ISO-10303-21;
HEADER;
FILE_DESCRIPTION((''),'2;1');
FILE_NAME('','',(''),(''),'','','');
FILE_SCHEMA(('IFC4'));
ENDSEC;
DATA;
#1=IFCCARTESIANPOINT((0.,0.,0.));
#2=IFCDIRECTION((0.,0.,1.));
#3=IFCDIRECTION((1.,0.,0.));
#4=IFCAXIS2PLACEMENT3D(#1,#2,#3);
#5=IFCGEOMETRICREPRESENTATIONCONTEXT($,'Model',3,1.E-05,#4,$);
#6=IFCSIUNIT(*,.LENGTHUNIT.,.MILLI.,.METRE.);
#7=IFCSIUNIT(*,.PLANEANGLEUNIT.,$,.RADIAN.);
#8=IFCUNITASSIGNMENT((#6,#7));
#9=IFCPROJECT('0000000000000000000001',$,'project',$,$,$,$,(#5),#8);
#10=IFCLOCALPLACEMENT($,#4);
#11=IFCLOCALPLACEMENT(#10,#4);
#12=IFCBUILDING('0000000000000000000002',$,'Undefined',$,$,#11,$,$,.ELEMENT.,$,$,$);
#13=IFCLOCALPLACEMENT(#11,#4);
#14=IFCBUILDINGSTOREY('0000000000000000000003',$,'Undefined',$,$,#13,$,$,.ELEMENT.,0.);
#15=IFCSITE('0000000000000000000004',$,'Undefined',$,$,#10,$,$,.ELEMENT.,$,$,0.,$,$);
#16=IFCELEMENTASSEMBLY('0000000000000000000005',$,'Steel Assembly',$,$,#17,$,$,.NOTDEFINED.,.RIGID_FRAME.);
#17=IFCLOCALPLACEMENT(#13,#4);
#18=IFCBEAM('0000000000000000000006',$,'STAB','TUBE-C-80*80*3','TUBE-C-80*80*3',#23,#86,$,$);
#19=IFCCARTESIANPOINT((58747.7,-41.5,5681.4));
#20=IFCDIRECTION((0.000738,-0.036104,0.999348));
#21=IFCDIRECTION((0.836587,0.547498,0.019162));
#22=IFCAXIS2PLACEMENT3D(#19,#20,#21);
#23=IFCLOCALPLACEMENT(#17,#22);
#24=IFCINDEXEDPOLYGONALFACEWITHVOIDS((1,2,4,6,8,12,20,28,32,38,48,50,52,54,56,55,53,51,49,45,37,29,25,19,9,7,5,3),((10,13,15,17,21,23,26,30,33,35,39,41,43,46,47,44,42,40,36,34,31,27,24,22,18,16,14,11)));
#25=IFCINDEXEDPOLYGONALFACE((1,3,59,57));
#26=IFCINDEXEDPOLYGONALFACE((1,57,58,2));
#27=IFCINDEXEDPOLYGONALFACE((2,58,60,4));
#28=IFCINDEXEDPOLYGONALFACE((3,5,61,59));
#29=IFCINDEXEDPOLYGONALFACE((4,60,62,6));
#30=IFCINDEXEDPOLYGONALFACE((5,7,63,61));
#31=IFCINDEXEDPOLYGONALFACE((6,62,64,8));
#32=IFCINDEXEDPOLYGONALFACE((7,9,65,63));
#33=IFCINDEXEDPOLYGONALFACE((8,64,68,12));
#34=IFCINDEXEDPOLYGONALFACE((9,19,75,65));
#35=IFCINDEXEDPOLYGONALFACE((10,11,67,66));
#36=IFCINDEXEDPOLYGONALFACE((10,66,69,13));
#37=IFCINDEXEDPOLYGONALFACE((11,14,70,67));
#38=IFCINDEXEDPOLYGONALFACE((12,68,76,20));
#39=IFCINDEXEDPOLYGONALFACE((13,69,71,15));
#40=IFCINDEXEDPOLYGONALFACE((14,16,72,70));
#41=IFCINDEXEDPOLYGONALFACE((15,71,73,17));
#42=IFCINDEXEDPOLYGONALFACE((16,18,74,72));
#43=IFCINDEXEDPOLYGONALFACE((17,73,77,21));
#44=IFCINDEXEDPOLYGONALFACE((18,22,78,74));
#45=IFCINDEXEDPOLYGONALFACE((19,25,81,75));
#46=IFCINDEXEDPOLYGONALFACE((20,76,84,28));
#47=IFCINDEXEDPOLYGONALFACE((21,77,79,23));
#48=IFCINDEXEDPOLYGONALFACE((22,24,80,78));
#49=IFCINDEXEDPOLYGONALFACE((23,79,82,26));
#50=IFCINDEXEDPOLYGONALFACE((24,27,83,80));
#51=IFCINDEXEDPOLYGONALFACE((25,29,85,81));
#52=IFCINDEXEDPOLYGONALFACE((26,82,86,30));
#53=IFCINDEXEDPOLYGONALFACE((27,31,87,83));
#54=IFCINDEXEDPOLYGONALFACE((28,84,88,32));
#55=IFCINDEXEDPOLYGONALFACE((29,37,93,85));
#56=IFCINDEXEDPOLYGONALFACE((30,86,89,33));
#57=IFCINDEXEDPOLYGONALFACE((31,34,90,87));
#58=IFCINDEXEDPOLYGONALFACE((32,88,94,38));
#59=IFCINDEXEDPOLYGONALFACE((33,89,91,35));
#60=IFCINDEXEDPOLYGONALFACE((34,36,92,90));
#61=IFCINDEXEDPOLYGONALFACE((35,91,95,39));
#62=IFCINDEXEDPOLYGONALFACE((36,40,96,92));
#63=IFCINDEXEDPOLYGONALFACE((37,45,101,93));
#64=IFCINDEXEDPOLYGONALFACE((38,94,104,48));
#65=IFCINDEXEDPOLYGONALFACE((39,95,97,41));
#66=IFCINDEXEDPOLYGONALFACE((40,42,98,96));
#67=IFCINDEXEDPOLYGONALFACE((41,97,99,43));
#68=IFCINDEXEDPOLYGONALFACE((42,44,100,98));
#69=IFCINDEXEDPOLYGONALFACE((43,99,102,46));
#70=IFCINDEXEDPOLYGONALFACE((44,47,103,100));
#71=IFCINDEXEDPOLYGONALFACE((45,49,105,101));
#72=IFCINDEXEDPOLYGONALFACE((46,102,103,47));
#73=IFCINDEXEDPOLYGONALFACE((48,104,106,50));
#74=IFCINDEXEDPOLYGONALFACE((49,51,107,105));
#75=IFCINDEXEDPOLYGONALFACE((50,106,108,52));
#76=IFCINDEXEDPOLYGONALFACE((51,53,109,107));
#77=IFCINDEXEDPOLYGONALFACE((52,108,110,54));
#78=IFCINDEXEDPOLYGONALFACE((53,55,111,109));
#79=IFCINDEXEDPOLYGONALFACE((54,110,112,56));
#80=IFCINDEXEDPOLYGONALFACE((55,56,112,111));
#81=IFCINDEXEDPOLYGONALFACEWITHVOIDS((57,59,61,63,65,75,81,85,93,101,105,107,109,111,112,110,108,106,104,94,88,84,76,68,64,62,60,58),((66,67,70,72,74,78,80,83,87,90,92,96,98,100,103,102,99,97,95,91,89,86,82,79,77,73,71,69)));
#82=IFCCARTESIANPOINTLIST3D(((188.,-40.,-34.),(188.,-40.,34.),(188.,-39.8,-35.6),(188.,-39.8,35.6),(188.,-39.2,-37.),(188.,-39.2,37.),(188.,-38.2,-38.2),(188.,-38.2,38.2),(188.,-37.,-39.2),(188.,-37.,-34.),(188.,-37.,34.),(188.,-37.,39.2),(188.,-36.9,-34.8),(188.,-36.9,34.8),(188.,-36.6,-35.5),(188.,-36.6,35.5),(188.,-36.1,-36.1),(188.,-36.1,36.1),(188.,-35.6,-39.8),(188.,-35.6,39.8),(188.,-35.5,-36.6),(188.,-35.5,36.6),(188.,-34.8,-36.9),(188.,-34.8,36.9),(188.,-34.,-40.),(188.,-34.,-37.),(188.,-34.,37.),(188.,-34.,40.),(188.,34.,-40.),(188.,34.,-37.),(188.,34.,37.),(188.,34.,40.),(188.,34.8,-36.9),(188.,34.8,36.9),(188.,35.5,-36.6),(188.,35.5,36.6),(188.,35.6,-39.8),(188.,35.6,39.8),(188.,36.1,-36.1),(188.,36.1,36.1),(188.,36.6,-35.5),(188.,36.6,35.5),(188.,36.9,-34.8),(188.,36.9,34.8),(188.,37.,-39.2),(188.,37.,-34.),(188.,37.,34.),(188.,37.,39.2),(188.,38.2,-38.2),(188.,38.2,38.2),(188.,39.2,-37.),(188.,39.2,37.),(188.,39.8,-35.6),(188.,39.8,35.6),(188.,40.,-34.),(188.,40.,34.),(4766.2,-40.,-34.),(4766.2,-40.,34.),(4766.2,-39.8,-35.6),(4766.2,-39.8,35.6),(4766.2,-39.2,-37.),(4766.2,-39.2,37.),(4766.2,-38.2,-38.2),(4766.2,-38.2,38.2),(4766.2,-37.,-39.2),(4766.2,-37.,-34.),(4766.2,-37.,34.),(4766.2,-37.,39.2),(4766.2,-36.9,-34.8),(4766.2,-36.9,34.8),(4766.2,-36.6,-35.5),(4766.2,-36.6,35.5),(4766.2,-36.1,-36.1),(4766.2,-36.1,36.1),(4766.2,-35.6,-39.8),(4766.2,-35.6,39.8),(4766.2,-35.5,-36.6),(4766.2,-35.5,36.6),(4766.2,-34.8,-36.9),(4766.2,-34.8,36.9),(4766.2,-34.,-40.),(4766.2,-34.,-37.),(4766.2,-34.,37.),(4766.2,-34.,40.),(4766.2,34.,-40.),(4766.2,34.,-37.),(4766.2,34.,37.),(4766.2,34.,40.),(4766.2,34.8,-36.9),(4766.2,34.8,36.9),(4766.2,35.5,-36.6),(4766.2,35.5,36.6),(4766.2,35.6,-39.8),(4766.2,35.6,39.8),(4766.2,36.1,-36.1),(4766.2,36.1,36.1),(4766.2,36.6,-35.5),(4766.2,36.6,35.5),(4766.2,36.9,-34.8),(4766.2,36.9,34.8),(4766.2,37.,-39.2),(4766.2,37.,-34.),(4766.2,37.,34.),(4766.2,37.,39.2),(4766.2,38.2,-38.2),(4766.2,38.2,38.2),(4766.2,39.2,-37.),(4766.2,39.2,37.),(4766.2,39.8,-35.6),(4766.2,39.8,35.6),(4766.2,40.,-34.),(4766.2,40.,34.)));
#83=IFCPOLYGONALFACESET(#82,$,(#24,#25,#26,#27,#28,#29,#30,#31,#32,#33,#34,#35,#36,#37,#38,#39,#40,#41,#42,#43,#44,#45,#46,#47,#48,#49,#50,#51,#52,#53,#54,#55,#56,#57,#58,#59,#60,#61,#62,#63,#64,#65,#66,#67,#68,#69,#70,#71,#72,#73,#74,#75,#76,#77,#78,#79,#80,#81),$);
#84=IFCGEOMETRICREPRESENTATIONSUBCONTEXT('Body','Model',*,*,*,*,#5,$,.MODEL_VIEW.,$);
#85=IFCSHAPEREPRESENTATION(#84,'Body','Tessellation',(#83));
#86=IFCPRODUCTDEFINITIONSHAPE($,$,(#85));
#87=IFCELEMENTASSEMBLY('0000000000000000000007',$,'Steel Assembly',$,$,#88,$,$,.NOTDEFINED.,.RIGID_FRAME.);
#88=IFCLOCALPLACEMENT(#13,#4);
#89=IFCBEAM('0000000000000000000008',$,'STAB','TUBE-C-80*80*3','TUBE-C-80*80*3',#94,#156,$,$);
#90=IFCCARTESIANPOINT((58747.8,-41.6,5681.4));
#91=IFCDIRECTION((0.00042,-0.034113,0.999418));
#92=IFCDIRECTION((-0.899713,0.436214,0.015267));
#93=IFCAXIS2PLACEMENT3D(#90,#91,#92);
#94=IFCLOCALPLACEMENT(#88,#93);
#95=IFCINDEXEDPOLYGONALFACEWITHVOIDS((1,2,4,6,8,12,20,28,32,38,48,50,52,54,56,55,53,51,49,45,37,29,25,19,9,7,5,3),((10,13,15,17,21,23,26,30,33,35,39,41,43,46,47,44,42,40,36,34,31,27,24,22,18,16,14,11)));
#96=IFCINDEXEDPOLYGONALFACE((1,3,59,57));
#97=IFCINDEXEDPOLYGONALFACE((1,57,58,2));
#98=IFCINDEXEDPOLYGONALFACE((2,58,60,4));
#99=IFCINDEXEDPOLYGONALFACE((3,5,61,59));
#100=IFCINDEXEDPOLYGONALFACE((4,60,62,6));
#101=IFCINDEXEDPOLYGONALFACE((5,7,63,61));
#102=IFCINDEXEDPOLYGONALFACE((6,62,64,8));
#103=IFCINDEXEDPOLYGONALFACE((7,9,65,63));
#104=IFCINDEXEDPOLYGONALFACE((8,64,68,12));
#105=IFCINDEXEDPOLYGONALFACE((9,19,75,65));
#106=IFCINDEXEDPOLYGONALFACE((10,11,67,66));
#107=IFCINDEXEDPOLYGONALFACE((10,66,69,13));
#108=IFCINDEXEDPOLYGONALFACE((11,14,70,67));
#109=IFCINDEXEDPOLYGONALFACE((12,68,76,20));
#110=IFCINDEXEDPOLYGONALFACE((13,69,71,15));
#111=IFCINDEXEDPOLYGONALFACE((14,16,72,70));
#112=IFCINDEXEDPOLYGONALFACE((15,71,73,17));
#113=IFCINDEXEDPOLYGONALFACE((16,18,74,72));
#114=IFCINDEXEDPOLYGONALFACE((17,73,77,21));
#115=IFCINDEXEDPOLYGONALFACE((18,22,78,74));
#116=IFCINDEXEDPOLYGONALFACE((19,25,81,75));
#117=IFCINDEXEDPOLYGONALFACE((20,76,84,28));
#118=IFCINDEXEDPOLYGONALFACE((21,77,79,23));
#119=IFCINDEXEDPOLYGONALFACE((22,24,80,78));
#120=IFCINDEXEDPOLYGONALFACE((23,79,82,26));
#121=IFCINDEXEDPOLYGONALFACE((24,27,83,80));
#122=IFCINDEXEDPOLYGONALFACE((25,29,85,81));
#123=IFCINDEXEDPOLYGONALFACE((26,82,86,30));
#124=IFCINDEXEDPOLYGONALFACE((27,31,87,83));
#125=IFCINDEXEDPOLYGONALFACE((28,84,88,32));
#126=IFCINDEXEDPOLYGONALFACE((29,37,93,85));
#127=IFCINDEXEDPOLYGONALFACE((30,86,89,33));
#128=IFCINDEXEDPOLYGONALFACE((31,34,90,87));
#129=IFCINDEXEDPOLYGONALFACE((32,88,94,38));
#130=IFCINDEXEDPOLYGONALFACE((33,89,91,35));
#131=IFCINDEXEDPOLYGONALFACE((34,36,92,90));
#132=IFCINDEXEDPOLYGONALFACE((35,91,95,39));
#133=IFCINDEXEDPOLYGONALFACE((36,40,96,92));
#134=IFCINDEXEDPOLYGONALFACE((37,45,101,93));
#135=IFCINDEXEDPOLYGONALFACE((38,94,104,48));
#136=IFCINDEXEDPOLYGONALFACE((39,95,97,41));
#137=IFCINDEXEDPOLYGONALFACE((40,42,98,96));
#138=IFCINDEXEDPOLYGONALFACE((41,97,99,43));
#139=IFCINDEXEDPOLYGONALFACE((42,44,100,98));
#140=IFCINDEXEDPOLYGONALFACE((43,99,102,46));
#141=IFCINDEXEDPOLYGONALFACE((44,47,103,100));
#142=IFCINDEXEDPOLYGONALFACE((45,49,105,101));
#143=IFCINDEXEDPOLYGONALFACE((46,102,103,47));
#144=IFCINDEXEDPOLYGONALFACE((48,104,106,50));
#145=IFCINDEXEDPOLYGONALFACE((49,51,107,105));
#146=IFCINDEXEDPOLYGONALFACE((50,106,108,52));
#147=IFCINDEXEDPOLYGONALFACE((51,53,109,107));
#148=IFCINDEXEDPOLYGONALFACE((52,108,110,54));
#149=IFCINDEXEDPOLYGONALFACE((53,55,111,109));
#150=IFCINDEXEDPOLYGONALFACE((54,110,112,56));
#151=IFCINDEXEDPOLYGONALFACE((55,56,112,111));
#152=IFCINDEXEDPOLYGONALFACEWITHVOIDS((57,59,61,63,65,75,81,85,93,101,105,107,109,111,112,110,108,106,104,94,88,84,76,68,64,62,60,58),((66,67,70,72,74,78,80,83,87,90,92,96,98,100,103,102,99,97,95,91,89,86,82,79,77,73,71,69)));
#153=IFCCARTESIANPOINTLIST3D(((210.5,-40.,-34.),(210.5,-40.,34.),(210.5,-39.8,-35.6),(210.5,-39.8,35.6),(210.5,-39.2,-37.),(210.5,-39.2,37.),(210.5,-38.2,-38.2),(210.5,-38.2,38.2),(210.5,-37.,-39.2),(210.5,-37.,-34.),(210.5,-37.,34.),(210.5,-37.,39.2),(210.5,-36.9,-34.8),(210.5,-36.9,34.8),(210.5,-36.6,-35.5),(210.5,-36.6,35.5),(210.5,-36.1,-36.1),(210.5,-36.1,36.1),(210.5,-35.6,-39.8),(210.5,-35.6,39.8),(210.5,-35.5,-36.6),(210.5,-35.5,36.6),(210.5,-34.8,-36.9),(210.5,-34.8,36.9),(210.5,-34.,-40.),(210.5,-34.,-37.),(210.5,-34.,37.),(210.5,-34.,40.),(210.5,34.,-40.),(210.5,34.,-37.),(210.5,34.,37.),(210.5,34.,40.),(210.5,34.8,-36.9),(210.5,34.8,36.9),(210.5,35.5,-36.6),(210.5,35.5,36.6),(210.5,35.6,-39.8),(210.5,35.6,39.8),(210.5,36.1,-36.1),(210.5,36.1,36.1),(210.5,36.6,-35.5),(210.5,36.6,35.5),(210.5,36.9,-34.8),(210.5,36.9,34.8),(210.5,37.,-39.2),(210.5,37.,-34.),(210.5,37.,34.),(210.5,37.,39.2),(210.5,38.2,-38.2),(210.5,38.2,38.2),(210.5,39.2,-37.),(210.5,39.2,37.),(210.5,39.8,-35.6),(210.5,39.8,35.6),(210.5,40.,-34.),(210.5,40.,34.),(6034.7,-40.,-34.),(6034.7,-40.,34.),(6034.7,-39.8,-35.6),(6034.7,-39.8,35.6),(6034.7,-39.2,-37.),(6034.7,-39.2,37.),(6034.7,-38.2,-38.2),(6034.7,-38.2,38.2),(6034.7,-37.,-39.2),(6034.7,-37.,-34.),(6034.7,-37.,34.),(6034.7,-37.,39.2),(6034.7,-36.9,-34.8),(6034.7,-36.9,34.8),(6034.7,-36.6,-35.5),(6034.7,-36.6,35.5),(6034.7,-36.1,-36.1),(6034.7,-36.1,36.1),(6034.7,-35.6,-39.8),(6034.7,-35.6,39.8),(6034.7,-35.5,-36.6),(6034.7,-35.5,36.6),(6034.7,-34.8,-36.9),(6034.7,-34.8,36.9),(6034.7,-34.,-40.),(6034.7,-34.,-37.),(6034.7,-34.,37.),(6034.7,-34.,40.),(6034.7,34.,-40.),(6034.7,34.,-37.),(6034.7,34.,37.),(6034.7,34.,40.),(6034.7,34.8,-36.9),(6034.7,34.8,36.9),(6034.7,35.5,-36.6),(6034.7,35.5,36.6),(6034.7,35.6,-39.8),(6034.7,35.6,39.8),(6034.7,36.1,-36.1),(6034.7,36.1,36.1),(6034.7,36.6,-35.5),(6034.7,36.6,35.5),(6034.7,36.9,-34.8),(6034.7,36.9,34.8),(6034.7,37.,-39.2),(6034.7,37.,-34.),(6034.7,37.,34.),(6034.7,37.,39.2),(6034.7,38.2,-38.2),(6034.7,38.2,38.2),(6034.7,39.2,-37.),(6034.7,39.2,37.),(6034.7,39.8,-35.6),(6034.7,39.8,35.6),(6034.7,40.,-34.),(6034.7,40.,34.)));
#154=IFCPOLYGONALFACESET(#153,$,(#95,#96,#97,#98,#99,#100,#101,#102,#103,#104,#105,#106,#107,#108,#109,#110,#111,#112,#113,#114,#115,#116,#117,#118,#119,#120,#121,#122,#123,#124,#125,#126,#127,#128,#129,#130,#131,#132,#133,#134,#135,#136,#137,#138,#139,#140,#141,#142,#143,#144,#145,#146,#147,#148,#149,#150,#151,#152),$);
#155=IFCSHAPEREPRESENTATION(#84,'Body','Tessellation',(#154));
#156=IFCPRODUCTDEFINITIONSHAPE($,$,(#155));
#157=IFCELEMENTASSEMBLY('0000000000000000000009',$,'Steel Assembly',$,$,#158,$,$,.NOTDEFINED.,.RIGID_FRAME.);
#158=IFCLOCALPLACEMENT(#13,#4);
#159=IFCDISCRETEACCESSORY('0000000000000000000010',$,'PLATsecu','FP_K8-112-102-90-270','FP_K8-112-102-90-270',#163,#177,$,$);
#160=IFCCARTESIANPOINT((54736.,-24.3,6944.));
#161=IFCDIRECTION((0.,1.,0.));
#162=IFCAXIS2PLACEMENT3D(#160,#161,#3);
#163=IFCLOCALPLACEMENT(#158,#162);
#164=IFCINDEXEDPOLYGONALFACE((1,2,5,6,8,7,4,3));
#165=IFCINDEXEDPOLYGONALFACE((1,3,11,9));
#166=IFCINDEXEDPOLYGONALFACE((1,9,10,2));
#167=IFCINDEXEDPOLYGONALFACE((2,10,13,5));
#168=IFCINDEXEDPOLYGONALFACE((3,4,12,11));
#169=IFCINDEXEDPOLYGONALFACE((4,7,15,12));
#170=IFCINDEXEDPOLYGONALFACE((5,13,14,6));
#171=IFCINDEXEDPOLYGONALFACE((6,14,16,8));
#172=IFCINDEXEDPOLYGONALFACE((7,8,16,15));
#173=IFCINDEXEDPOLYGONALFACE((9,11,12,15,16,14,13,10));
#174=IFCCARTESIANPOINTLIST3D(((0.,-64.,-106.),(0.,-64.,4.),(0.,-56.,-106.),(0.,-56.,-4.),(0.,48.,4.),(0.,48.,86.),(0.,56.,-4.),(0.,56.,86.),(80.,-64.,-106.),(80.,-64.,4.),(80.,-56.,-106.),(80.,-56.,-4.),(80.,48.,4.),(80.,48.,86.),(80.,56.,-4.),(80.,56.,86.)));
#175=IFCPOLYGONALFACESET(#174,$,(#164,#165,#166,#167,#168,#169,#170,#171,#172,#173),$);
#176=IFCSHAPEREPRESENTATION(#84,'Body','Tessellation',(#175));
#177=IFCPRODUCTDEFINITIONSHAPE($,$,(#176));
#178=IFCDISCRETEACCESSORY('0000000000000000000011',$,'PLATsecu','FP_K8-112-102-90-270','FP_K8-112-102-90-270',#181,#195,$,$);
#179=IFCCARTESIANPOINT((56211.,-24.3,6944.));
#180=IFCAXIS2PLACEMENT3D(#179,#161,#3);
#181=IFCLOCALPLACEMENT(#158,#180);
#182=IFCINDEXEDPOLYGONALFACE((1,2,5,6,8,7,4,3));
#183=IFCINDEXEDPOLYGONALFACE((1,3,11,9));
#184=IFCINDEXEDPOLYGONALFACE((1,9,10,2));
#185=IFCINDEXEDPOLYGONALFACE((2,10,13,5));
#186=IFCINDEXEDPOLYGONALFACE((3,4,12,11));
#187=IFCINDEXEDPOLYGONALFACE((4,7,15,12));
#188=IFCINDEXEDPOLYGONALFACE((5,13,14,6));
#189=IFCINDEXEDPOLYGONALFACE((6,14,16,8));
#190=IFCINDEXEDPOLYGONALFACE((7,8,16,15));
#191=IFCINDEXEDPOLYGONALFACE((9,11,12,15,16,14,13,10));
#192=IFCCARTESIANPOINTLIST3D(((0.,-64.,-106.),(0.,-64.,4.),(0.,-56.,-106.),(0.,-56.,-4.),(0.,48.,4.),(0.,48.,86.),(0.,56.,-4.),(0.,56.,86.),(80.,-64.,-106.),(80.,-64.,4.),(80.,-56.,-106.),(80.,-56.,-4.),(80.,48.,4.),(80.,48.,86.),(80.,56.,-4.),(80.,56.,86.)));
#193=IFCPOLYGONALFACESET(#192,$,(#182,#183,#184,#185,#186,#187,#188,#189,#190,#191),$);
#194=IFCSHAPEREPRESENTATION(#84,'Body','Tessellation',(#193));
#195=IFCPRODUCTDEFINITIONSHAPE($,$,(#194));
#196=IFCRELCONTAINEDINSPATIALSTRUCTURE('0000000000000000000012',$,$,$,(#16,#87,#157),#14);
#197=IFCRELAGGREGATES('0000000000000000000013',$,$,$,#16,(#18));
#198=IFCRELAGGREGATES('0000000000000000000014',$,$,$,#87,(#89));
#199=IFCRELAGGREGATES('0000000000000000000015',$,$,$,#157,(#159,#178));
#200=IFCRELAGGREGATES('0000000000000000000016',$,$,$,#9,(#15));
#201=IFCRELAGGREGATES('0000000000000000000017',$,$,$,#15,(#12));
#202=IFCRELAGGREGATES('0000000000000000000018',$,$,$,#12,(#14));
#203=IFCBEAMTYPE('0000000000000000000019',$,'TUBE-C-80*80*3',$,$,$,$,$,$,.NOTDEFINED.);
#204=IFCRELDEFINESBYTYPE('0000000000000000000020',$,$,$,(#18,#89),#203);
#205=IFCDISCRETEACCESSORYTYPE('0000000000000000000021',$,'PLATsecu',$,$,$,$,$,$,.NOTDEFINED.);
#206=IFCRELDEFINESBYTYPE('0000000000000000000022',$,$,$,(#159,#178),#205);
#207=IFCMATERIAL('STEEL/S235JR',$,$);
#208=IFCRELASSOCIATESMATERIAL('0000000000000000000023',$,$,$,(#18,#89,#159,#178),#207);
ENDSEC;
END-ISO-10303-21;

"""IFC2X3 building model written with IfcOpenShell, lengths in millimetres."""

from ifc_helpers import new_model, si_unit, frame, origin_with_axes, origin_2d_with_axis, place, context, subcontext, project, spatial, polyline, hollow_rectangle, outline, extrude, clip, halfspace, material, type_object, element, aggregate, save


model = new_model("IFC2X3")

# Units and contexts
model_context = context("Model", 3, precision=1e-05, world=origin_with_axes())
body_context = subcontext(model_context, "Body", "Model", "MODEL_VIEW")
ifc_project = project(units=[si_unit("LENGTHUNIT", "METRE", prefix="MILLI"), si_unit("PLANEANGLEUNIT", "RADIAN")], contexts=[model_context])

# Site, building, storey
site_placement = place(None, origin_with_axes())
site = spatial("IfcSite", under=ifc_project, at=site_placement, Name="Undefined", CompositionType="ELEMENT", RefElevation=0.0)
building_placement = place(site_placement, origin_with_axes())
building = spatial("IfcBuilding", under=site, at=building_placement, Name="Undefined", CompositionType="ELEMENT")
storey_placement = place(building_placement, origin_with_axes())
storey = spatial("IfcBuildingStorey", under=building, at=storey_placement, Name="Undefined", CompositionType="ELEMENT", Elevation=0.0)

# Element assemblies, beams
ifc_material_1 = material(Name="STEEL/S235JR")
assembly_1_placement = place(storey_placement, origin_with_axes())
assembly_1 = element("IfcElementAssembly", 1, at=assembly_1_placement, inside=storey, Name="Steel Assembly", AssemblyPlace="NOTDEFINED", PredefinedType="RIGID_FRAME")
beam_type_1 = type_object("IfcBeamType", Name="TUBE-C-80*80*3", PredefinedType="NOTDEFINED")
beam_1_placement = place(assembly_1_placement, frame((58747.7, -41.5, 5681.4), z_axis=(0.000738, -0.036104, 0.999348), x_axis=(0.836587, 0.547498, 0.019162)))
beam_1 = element("IfcBeam", 2, at=beam_1_placement, type_object=beam_type_1, material=ifc_material_1, Name="STAB", Description="TUBE-C-80*80*3", ObjectType="TUBE-C-80*80*3", context=body_context, shape_type="Clipping", body=[
    clip(clip(extrude(hollow_rectangle(XDim=80.0, YDim=80.0, WallThickness=3.0, InnerFilletRadius=3.0, OuterFilletRadius=6.0, at=origin_2d_with_axis()), frame((4766.2, 0.0, 0.0), z_axis=(-1.0, 0.0, 0.0), x_axis=(0.0, -1.0, 0.0)), (0.0, 0.0, 1.0), 4578.2), halfspace(frame((4766.2, -1.3, -1000.0), z_axis=(-1.0, 0.0, 0.0), x_axis=(0.0, 0.999999, -0.001346)), True)), halfspace(frame((188.0, -1.3, -1000.0), z_axis=(1.0, 0.0, 0.0), x_axis=(0.0, -0.999999, 0.001346)), True)),
])
aggregate(assembly_1, [beam_1])
assembly_2_placement = place(storey_placement, origin_with_axes())
assembly_2 = element("IfcElementAssembly", 3, at=assembly_2_placement, inside=storey, Name="Steel Assembly", AssemblyPlace="NOTDEFINED", PredefinedType="RIGID_FRAME")
beam_2_placement = place(assembly_2_placement, frame((58747.8, -41.6, 5681.4), z_axis=(0.00042, -0.034113, 0.999418), x_axis=(-0.899713, 0.436214, 0.015267)))
beam_2 = element("IfcBeam", 4, at=beam_2_placement, type_object=beam_type_1, material=ifc_material_1, Name="STAB", Description="TUBE-C-80*80*3", ObjectType="TUBE-C-80*80*3", context=body_context, shape_type="Clipping", body=[
    clip(clip(extrude(hollow_rectangle(XDim=80.0, YDim=80.0, WallThickness=3.0, InnerFilletRadius=3.0, OuterFilletRadius=6.0, at=origin_2d_with_axis()), frame((6034.7, 0.0, 0.0), z_axis=(-1.0, 0.0, 0.0), x_axis=(0.0, -1.0, 0.0)), (0.0, 0.0, 1.0), 5824.2), halfspace(frame((6034.7, -1.0, -1000.0), z_axis=(-1.0, 0.0, 0.0), x_axis=(0.0, 1.0, -0.000963)), True)), halfspace(frame((210.5, -1.0, -1000.0), z_axis=(1.0, 0.0, 0.0), x_axis=(0.0, -1.0, 0.000963)), True)),
])
assembly_3_placement = place(storey_placement, origin_with_axes())
assembly_3 = element("IfcElementAssembly", 5, at=assembly_3_placement, inside=storey, Name="Steel Assembly", AssemblyPlace="NOTDEFINED", PredefinedType="RIGID_FRAME")

aggregate(assembly_2, [beam_2])

# Discrete accessories
discrete_accessory_type_1 = type_object("IfcDiscreteAccessoryType", Name="PLATsecu")
discrete_accessory_1_placement = place(assembly_3_placement, frame((54736.0, -24.3, 6944.0), z_axis=(0.0, 1.0, 0.0), x_axis=(1.0, 0.0, 0.0)))
discrete_accessory_1 = element("IfcDiscreteAccessory", 6, at=discrete_accessory_1_placement, type_object=discrete_accessory_type_1, material=ifc_material_1, Name="PLATsecu", Description="FP_K8-112-102-90-270", ObjectType="FP_K8-112-102-90-270", context=body_context, shape_type="SweptSolid", body=[
    extrude(outline(polyline([(-56.0, 86.0), (-48.0, 86.0), (-48.0, 4.0), (64.0, 4.0), (64.0, -106.0), (56.0, -106.0), (56.0, -4.0), (-56.0, -4.0), (-56.0, 86.0)])), frame((80.0, 0.0, 0.0), z_axis=(-1.0, 0.0, 0.0), x_axis=(0.0, -1.0, 0.0)), (0.0, 0.0, 1.0), 80.0),
])
discrete_accessory_2_placement = place(assembly_3_placement, frame((56211.0, -24.3, 6944.0), z_axis=(0.0, 1.0, 0.0), x_axis=(1.0, 0.0, 0.0)))
discrete_accessory_2 = element("IfcDiscreteAccessory", 7, at=discrete_accessory_2_placement, type_object=discrete_accessory_type_1, material=ifc_material_1, Name="PLATsecu", Description="FP_K8-112-102-90-270", ObjectType="FP_K8-112-102-90-270", context=body_context, shape_type="SweptSolid", body=[
    extrude(outline(polyline([(-56.0, 86.0), (-48.0, 86.0), (-48.0, 4.0), (64.0, 4.0), (64.0, -106.0), (56.0, -106.0), (56.0, -4.0), (-56.0, -4.0), (-56.0, 86.0)])), frame((80.0, 0.0, 0.0), z_axis=(-1.0, 0.0, 0.0), x_axis=(0.0, -1.0, 0.0)), (0.0, 0.0, 1.0), 80.0),
])
aggregate(assembly_3, [discrete_accessory_1, discrete_accessory_2])

save(model, "model.ifc")
